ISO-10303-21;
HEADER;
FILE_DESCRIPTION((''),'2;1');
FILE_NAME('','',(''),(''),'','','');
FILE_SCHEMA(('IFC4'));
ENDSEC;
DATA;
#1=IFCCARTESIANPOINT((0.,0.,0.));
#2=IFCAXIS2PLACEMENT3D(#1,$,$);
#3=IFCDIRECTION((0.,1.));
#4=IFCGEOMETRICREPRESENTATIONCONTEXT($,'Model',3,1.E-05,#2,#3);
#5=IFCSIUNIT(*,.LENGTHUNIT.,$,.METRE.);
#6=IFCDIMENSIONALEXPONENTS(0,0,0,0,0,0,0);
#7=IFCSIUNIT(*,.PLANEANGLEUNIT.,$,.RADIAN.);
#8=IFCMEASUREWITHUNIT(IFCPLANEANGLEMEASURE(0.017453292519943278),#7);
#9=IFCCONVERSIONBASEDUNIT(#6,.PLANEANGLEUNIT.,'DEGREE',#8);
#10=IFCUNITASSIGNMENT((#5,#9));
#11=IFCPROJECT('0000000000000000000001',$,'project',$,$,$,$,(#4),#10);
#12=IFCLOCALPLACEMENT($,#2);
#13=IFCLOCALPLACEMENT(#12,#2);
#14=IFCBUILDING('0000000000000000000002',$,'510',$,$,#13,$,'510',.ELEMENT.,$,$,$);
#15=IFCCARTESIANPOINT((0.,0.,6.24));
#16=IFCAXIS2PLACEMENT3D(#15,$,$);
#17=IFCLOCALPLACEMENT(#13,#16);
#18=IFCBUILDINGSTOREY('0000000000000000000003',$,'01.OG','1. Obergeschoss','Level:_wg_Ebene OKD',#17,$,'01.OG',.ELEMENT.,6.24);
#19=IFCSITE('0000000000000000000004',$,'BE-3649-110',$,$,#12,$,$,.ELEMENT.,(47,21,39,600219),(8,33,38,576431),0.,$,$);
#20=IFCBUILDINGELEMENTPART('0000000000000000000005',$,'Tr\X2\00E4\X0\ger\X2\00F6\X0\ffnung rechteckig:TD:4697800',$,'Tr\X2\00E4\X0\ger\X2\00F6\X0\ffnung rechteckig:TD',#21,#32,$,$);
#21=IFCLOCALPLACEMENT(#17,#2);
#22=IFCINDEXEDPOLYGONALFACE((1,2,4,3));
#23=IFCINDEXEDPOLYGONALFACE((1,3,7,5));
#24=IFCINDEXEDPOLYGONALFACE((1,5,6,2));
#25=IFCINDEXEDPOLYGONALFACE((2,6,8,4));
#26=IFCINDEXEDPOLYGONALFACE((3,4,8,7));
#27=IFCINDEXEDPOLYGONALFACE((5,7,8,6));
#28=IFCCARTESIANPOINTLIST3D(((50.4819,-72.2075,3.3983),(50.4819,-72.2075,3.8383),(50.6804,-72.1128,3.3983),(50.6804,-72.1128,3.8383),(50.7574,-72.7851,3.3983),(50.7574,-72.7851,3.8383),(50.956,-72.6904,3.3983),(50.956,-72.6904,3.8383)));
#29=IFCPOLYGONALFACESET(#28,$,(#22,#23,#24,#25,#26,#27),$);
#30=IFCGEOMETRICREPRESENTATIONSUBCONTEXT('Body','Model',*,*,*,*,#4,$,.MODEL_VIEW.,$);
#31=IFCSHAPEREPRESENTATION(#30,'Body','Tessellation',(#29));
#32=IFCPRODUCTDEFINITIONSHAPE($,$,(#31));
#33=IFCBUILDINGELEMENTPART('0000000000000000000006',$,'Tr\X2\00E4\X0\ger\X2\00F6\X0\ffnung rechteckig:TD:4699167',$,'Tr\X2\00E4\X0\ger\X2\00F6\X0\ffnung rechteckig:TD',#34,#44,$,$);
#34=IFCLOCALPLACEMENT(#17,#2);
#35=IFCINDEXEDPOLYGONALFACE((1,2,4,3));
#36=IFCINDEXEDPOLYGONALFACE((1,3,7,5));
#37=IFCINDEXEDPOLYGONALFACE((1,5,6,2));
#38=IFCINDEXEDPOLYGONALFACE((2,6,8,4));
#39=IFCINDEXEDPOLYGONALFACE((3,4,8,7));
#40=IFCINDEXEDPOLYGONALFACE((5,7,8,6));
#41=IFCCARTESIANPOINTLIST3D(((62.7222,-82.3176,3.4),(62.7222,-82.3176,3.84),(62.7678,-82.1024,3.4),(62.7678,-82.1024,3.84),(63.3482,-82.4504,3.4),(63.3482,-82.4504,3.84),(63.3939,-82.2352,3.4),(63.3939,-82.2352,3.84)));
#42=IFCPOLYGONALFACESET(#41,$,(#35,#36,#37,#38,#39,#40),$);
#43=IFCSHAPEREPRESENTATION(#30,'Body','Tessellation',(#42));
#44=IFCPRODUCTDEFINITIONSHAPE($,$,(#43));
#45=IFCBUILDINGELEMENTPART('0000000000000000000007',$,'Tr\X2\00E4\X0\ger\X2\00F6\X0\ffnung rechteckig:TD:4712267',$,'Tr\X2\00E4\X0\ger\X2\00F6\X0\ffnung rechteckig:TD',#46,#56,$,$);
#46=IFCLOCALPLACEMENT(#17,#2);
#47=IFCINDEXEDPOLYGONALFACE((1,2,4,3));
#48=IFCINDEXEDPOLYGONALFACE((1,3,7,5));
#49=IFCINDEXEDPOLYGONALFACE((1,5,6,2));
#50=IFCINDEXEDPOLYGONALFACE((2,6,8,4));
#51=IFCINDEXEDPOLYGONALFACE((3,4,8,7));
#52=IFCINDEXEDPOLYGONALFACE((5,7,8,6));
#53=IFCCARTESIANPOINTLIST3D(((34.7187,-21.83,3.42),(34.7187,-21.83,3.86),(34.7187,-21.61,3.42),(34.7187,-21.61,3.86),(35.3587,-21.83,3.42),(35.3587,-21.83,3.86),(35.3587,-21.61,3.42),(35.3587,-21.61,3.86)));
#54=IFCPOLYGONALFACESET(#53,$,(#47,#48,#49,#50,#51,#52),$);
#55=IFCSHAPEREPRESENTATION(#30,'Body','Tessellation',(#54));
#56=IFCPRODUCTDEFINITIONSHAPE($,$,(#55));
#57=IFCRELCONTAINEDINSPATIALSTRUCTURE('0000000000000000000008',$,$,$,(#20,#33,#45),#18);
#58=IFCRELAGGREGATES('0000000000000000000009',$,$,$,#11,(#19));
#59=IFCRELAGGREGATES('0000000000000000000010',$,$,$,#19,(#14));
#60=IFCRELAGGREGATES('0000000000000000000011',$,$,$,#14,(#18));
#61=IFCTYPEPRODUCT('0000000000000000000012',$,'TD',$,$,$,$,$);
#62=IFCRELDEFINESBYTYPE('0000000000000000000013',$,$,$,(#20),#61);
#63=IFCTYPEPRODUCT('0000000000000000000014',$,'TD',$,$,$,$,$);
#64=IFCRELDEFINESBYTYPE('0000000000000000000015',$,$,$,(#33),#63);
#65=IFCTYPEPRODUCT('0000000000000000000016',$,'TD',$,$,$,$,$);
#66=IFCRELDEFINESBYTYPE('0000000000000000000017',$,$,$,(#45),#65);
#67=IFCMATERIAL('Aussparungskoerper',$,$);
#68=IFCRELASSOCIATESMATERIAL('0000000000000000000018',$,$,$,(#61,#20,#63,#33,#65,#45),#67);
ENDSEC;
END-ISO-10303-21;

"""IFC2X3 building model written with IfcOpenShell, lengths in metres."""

from ifc_helpers import new_model, entity, si_unit, converted_unit, direction, frame, frame_2d, origin, origin_2d_with_axis, place, context, subcontext, project, spatial, rectangle, extrude, source, transform, mapped, material, type_object, type_shapes, element, save


model = new_model("IFC2X3")

# Units and contexts
model_context = context("Model", 3, precision=1e-05, world=origin(), true_north=direction((0.0, 1.0)))
body_context = subcontext(model_context, "Body", "Model", "MODEL_VIEW")
ifc_project = project(units=[si_unit("LENGTHUNIT", "METRE"), converted_unit("PLANEANGLEUNIT", "DEGREE", entity("IfcPlaneAngleMeasure", 0.017453292519943278), si_unit("PLANEANGLEUNIT", "RADIAN"), dimensions=[0, 0, 0, 0, 0, 0, 0])], contexts=[model_context])

# Site, building, storey
site_placement = place(None, origin())
site = spatial("IfcSite", under=ifc_project, at=site_placement, Name="BE-3649-110", CompositionType="ELEMENT", RefLatitude=(47, 21, 39, 600219), RefLongitude=(8, 33, 38, 576431), RefElevation=0.0)
building_placement = place(site_placement, origin())
building = spatial("IfcBuilding", under=site, at=building_placement, Name="510", LongName="510", CompositionType="ELEMENT")
storey_placement = place(building_placement, frame((0.0, 0.0, 6.24)))
storey = spatial("IfcBuildingStorey", under=building, at=storey_placement, Name="01.OG", Description="1. Obergeschoss", ObjectType="Level:_wg_Ebene OKD", LongName="01.OG", CompositionType="ELEMENT", Elevation=6.24)

# Building element parts
ifc_material_1 = material(Name="Aussparungskoerper")
type_product_1 = type_object("IfcTypeProduct", Name="TD", material=ifc_material_1)
shared_shape_1 = source(origin(), body_context, "Body", "SweptSolid", [
    extrude(rectangle(XDim=0.22, YDim=0.64, at=frame_2d((0.0, 0.0), x_axis=(1.0, 0.0))), frame((50.7189, -72.449, -0.44), z_axis=(0.0, 0.0, 1.0), x_axis=(0.902586, 0.43051, 0.0)), (0.0, 0.0, 1.0), 0.44),
])
type_shapes(type_product_1, [shared_shape_1])
building_element_part_1_placement = place(storey_placement, frame((0.0, 0.0, 3.8383)))
element("IfcBuildingElementPart", 1, at=building_element_part_1_placement, inside=storey, type_object=type_product_1, material=ifc_material_1, Name="Trägeröffnung rechteckig:TD:4697800", ObjectType="Trägeröffnung rechteckig:TD", context=body_context, shape_type="MappedRepresentation", body=[
    mapped(shared_shape_1, transform((0.0, 0.0, 0.0), scale=1.0)),
])
type_product_2 = type_object("IfcTypeProduct", Name="TD", material=ifc_material_1)
shared_shape_2 = source(origin(), body_context, "Body", "SweptSolid", [
    extrude(rectangle(XDim=0.44, YDim=0.64, at=origin_2d_with_axis()), frame((0.0, 0.0, -0.22), z_axis=(0.0, 0.0, 1.0), x_axis=(0.0, 1.0, 0.0)), (0.0, 0.0, 1.0), 0.22),
])
type_shapes(type_product_2, [shared_shape_2])
building_element_part_2_placement = place(storey_placement, frame((63.0352, -82.384, 3.62), z_axis=(-0.207566, -0.978221, 0.0), x_axis=(0.978221, -0.207566, 0.0)))
element("IfcBuildingElementPart", 2, at=building_element_part_2_placement, inside=storey, type_object=type_product_2, material=ifc_material_1, Name="Trägeröffnung rechteckig:TD:4699167", ObjectType="Trägeröffnung rechteckig:TD", context=body_context, shape_type="MappedRepresentation", body=[
    mapped(shared_shape_2, transform((0.0, 0.0, 0.0), scale=1.0)),
])
type_product_3 = type_object("IfcTypeProduct", Name="TD", material=ifc_material_1)
shared_shape_3 = source(origin(), body_context, "Body", "SweptSolid", [
    extrude(rectangle(XDim=0.22, YDim=0.64, at=frame_2d((0.0, 0.0), x_axis=(1.0, 0.0))), frame((35.0387, -21.72, -0.44), z_axis=(0.0, 0.0, 1.0), x_axis=(0.0, 1.0, 0.0)), (0.0, 0.0, 1.0), 0.44),
])
type_shapes(type_product_3, [shared_shape_3])
building_element_part_3_placement = place(storey_placement, frame((0.0, 0.0, 3.86)))
element("IfcBuildingElementPart", 3, at=building_element_part_3_placement, inside=storey, type_object=type_product_3, material=ifc_material_1, Name="Trägeröffnung rechteckig:TD:4712267", ObjectType="Trägeröffnung rechteckig:TD", context=body_context, shape_type="MappedRepresentation", body=[
    mapped(shared_shape_3, transform((0.0, 0.0, 0.0), scale=1.0)),
])

save(model, "model.ifc")
